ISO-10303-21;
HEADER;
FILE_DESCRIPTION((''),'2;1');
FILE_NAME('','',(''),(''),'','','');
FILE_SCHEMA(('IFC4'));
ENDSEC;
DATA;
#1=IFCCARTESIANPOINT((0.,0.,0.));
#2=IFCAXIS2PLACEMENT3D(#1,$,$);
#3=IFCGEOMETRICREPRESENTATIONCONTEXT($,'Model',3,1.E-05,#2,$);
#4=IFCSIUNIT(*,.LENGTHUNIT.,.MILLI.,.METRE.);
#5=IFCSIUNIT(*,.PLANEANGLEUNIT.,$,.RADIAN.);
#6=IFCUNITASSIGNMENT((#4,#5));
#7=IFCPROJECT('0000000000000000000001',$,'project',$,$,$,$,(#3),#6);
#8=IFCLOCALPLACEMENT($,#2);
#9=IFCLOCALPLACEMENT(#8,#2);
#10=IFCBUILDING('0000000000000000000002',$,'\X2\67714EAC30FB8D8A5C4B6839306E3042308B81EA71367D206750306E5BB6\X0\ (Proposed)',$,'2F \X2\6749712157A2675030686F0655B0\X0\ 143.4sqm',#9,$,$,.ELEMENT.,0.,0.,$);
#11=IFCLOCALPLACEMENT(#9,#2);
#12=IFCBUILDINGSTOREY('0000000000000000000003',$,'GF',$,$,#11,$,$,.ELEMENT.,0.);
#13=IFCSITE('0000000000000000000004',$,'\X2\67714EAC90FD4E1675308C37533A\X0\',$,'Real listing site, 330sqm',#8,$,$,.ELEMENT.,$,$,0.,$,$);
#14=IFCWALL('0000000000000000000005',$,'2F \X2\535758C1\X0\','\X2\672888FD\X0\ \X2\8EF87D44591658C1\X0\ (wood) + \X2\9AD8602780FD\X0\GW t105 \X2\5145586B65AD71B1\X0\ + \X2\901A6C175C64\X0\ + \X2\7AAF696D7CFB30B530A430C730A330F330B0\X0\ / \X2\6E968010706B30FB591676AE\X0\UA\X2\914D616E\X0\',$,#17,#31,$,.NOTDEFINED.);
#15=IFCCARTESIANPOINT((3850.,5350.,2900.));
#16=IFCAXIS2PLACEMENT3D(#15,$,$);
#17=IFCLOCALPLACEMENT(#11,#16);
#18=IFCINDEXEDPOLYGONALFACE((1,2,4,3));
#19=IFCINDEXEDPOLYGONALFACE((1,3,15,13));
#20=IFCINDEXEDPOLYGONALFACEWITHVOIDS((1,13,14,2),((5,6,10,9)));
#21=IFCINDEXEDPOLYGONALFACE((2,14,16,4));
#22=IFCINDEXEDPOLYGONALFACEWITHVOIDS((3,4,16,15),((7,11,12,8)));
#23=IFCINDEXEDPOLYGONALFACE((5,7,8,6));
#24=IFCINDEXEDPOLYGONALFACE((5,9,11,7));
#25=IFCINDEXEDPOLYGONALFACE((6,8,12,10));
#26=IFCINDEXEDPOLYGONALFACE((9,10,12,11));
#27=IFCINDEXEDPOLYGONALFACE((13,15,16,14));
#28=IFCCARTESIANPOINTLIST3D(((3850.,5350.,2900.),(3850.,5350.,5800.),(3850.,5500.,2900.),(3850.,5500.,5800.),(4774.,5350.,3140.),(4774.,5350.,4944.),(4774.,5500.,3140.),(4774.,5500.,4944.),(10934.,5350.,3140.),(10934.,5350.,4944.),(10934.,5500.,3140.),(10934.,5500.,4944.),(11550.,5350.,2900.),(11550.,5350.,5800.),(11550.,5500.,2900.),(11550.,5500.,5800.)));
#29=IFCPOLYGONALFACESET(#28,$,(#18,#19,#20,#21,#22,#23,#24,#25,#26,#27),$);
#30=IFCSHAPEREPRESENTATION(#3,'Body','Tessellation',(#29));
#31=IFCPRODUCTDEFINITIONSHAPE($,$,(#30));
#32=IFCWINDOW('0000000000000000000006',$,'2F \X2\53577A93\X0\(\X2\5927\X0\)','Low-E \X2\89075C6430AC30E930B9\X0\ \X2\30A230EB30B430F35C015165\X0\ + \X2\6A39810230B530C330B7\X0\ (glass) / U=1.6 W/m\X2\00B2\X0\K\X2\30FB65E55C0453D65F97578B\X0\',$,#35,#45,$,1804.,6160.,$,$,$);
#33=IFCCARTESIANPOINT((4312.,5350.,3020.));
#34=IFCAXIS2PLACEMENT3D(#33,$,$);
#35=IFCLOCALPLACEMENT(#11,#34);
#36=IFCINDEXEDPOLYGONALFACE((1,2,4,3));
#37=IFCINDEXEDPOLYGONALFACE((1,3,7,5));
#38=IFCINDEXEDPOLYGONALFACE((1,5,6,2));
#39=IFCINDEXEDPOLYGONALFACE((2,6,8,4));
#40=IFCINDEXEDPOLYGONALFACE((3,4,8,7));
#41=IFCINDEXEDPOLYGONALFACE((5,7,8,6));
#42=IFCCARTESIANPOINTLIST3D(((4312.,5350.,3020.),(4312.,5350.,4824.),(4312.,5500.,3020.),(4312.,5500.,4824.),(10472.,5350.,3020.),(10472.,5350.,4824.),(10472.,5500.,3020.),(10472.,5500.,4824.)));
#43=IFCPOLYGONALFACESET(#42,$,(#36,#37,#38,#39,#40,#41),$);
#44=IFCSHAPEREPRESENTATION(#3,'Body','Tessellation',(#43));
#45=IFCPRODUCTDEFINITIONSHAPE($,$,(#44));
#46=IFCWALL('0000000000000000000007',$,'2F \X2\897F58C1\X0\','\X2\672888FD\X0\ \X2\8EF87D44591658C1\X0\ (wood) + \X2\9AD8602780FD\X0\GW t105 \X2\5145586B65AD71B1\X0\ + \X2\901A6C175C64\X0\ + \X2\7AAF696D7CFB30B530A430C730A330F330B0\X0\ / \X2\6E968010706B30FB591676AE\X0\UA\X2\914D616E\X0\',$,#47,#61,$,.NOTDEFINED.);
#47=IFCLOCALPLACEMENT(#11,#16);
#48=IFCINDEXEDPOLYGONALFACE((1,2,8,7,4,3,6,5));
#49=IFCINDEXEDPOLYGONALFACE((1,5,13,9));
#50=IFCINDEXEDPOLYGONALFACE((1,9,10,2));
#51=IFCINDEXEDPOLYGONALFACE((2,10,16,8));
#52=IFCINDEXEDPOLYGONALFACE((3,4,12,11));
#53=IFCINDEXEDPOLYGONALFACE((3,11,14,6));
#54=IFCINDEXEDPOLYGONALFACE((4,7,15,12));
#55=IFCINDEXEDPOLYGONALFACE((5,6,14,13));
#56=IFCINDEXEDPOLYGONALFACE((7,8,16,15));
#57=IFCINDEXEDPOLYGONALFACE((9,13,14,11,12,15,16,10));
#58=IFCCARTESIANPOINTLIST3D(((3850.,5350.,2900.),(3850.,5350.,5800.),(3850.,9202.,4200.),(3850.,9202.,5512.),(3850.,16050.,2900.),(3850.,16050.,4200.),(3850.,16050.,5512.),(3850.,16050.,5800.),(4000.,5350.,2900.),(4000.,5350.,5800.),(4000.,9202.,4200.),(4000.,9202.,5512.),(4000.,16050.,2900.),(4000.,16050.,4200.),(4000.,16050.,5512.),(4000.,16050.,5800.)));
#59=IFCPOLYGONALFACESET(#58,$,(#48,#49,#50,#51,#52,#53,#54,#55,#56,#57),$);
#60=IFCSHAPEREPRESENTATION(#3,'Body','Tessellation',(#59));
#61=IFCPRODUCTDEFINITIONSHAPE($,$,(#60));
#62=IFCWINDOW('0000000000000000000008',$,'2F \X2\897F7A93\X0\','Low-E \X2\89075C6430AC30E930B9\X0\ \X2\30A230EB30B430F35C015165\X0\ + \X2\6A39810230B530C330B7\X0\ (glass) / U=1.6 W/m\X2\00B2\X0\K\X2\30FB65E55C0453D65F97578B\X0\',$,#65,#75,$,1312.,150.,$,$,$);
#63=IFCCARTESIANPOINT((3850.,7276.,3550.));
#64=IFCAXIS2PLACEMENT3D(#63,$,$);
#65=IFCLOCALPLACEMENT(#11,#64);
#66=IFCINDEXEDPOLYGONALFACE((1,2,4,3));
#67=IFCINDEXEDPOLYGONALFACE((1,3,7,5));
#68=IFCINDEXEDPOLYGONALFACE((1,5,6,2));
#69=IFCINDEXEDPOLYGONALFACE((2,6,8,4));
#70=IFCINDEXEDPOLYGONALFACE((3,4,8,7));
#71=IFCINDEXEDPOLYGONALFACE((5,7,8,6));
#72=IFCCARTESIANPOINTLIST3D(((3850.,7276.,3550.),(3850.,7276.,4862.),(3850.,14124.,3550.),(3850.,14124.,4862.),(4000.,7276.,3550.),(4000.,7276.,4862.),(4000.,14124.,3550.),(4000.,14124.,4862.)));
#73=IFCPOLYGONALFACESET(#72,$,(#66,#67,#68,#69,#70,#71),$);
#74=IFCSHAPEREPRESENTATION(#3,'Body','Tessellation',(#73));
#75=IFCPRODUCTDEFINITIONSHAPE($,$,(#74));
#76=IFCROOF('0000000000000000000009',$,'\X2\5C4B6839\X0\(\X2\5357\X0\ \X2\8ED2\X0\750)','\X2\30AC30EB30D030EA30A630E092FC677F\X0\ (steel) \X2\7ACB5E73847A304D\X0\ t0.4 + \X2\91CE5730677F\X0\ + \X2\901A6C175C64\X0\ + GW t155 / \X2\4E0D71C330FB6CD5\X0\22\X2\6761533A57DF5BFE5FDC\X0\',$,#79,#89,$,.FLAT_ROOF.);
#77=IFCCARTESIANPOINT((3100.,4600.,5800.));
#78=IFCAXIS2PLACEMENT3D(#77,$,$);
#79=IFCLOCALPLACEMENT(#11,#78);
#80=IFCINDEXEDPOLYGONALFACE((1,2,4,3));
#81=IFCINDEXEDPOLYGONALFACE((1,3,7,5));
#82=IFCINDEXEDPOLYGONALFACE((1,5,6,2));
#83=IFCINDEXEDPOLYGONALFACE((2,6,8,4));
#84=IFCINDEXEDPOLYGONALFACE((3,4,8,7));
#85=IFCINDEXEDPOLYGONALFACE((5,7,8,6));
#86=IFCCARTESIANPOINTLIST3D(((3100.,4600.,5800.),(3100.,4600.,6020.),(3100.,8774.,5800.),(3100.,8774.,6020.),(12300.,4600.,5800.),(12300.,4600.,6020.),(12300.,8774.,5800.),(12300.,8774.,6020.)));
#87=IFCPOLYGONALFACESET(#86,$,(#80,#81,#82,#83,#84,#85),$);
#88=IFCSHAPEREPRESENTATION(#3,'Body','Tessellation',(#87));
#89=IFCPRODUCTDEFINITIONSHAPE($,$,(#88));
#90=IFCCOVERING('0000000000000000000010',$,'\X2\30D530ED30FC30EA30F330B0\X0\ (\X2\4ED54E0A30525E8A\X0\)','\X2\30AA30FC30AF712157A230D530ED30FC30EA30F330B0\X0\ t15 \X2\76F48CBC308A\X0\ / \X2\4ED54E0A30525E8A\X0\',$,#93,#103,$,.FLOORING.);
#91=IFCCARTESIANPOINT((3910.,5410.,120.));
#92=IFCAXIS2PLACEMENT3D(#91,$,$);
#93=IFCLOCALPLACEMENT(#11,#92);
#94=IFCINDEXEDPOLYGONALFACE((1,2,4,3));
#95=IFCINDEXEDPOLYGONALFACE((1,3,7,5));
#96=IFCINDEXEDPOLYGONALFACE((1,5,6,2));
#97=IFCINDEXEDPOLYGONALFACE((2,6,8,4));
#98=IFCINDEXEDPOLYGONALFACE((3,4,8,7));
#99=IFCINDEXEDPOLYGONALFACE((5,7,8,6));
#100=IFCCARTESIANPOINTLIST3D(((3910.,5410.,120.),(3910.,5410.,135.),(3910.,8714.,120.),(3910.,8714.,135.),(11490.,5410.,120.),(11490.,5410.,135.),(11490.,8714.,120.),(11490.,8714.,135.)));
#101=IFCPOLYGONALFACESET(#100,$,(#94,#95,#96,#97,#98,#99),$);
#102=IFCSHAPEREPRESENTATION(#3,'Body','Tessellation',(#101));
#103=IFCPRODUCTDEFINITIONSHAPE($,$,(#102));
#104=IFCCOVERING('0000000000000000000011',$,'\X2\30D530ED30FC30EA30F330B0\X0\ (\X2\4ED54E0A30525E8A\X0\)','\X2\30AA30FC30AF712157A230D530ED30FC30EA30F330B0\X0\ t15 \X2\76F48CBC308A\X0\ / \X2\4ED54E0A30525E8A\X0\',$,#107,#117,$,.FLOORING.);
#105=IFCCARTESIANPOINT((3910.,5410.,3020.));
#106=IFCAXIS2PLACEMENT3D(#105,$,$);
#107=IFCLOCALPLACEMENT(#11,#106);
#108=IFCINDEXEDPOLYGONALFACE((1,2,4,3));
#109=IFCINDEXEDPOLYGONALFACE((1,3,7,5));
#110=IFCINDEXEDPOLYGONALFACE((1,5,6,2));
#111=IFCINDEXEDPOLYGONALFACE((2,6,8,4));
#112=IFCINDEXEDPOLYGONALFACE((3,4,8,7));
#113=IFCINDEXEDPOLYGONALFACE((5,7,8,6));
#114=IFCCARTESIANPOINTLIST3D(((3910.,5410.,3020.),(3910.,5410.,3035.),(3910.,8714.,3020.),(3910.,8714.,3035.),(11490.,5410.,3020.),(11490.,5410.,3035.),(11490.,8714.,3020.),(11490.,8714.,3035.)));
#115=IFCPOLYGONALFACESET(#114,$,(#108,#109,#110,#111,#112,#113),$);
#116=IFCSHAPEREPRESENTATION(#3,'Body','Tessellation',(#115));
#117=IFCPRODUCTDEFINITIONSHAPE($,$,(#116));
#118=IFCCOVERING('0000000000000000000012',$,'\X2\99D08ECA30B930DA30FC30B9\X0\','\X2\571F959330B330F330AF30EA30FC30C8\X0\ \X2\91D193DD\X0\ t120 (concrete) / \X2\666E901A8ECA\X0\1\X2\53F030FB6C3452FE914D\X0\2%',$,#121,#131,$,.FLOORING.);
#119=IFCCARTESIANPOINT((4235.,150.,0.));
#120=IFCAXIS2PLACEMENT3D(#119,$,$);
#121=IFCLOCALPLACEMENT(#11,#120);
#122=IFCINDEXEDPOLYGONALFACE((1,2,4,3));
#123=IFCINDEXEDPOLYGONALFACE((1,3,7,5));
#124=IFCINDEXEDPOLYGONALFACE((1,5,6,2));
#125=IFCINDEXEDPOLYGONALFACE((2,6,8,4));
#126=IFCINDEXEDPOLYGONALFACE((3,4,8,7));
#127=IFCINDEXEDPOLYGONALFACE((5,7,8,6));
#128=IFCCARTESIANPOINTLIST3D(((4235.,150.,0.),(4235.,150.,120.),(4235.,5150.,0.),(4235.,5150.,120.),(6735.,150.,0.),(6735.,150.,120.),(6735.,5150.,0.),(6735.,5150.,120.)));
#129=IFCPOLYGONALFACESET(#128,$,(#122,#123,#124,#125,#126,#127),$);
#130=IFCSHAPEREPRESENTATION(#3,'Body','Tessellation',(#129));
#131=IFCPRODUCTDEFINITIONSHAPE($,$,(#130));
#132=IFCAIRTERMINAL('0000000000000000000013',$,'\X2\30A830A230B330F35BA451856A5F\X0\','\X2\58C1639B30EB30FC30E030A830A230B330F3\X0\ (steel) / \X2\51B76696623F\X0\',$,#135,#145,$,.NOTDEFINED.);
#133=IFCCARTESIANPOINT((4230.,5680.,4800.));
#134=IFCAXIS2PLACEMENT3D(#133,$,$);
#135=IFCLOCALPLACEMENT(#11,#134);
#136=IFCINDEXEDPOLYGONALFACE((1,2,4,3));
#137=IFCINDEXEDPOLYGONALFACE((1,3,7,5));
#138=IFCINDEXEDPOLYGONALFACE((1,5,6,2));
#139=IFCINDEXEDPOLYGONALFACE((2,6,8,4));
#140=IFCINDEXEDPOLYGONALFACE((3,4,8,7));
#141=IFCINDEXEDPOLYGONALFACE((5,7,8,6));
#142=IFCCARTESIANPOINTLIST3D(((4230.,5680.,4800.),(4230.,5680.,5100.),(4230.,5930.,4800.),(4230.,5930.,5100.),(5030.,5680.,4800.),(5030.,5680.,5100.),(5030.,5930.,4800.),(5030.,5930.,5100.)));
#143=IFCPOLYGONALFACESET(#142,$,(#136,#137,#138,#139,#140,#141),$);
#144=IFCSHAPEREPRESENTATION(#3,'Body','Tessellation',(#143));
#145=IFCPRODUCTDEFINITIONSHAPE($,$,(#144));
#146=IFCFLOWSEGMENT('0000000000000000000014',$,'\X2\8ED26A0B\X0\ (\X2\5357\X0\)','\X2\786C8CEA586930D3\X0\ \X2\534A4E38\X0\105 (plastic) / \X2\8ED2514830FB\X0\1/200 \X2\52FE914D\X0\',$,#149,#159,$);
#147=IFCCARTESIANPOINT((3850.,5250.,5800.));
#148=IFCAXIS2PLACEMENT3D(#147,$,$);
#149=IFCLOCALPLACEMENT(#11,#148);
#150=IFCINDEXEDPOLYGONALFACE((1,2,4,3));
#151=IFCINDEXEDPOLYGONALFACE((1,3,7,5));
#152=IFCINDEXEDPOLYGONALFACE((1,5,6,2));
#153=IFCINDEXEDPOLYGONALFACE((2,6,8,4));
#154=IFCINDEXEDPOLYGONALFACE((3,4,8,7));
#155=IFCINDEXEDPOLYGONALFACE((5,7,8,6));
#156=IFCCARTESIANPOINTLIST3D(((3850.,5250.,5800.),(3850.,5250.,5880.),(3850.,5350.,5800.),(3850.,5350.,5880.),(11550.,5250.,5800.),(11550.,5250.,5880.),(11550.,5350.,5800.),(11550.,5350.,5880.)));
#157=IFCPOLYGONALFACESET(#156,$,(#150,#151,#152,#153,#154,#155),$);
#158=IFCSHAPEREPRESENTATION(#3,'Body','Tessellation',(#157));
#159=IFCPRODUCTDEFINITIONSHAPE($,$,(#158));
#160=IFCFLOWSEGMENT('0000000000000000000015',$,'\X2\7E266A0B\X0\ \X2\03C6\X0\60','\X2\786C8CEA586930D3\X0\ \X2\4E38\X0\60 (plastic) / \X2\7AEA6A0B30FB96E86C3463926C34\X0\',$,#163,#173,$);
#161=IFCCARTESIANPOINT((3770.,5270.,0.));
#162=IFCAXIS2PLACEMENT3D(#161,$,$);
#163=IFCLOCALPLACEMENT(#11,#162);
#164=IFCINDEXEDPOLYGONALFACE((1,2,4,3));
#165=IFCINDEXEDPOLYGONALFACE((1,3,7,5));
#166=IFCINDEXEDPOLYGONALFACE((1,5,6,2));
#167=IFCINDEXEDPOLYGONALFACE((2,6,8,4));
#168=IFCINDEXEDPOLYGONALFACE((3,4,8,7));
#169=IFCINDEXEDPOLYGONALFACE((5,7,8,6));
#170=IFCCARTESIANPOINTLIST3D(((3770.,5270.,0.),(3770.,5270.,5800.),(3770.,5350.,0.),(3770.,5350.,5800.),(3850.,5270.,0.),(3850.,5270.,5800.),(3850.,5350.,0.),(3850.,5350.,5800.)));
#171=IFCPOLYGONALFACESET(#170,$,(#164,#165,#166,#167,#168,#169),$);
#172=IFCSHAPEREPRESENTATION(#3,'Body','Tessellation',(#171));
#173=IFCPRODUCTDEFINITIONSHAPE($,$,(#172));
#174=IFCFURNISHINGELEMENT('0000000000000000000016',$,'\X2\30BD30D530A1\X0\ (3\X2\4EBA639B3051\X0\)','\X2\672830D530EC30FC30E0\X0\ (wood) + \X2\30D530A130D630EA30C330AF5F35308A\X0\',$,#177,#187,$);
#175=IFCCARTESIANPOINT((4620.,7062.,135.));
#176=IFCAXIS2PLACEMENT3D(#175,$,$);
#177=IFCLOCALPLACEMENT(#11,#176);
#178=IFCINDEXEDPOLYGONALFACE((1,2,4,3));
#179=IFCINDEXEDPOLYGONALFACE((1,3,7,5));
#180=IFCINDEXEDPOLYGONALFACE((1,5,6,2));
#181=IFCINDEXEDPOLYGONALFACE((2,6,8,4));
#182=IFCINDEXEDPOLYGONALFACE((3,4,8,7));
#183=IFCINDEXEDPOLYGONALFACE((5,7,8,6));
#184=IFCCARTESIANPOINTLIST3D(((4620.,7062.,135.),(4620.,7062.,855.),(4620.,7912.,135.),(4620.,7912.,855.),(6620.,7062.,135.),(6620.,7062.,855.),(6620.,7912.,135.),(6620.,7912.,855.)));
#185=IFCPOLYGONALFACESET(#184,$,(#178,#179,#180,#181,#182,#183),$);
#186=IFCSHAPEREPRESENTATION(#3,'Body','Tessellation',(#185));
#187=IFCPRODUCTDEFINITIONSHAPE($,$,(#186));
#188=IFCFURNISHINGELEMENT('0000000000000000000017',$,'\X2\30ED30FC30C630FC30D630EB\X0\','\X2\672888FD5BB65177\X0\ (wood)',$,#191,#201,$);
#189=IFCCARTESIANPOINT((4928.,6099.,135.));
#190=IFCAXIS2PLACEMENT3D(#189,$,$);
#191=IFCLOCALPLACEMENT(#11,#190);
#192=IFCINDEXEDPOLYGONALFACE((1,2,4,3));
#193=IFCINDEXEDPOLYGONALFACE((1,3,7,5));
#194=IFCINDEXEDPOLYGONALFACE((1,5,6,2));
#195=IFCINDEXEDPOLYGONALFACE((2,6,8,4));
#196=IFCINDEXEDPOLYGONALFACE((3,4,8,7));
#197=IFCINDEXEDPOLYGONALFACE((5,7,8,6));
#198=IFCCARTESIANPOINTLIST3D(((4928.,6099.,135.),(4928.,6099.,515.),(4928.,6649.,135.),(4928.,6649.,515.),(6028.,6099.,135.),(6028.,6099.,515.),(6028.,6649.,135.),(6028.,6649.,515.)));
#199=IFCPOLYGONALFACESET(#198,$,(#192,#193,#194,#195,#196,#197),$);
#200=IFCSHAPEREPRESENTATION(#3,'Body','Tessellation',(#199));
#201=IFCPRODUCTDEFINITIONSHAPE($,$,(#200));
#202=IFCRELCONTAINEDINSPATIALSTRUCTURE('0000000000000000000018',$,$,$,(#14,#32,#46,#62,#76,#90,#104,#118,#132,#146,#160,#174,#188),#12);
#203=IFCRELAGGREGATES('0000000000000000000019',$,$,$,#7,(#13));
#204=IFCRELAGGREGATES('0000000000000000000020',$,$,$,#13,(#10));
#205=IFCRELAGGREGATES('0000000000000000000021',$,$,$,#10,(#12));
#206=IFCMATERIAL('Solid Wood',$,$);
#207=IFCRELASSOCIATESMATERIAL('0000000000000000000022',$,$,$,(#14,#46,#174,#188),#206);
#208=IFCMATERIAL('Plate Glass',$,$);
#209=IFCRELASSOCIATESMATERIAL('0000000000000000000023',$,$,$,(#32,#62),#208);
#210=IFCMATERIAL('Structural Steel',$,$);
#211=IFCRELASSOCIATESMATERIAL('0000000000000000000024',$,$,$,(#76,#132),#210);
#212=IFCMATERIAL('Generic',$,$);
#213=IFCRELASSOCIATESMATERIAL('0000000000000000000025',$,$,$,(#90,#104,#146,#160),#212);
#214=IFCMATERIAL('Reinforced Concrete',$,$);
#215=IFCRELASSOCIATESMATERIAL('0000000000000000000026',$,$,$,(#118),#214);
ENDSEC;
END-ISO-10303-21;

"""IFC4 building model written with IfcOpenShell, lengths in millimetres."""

from ifc_helpers import new_model, si_unit, frame, frame_2d, origin, place, context, project, spatial, rectangle, extrude, material, element, fill, save


model = new_model("IFC4")

# Units and contexts
model_context = context("Model", 3, precision=1e-05, world=origin())
ifc_project = project(units=[si_unit("LENGTHUNIT", "METRE", prefix="MILLI"), si_unit("PLANEANGLEUNIT", "RADIAN")], contexts=[model_context])

# Site, building, storey
site_placement = place(None, origin())
site = spatial("IfcSite", under=ifc_project, at=site_placement, Name="東京都世田谷区", ObjectType="Real listing site, 330sqm", CompositionType="ELEMENT", RefElevation=0.0)
building_placement = place(site_placement, origin())
building = spatial("IfcBuilding", under=site, at=building_placement, Name="東京・越屋根のある自然素材の家 (Proposed)", ObjectType="2F 杉無垢材と漆喰 143.4sqm", CompositionType="ELEMENT", ElevationOfRefHeight=0.0, ElevationOfTerrain=0.0)
storey_placement = place(building_placement, origin())
storey = spatial("IfcBuildingStorey", under=building, at=storey_placement, Name="GF", CompositionType="ELEMENT", Elevation=0.0)

# Shared definitions
ifc_material_1 = material(Name="Solid Wood")

# Shared definitions
ifc_material_2 = material(Name="Reinforced Concrete")

# Shared definitions
ifc_material_3 = material(Name="Plate Glass")

# Walls, openings, windows
wall_1_placement = place(storey_placement, frame((3850.0, 5350.0, 2900.0)))
wall_1 = element("IfcWall", 1, at=wall_1_placement, inside=storey, material=ifc_material_1, Name="2F 南壁", Description="木製 軸組外壁 (wood) + 高性能GW t105 充填断熱 + 通気層 + 窯業系サイディング / 準耐火・外皮UA配慮", PredefinedType="NOTDEFINED", context=model_context, shape_type="SweptSolid", body=[
    extrude(rectangle(XDim=7700.0, YDim=150.0, at=frame_2d((3850.0, 75.0))), frame((3850.0, 5350.0, 2900.0)), (0.0, 0.0, 1.0), 2900.0),
])
opening_1_placement = place(storey_placement, frame((4312.0, 5350.0, 3020.0)))
opening_1 = element("IfcOpeningElement", 2, at=opening_1_placement, cuts=wall_1, PredefinedType="NOTDEFINED", context=model_context, shape_type="SweptSolid", body=[
    extrude(rectangle(XDim=6160.0, YDim=150.0, at=frame_2d((3080.0, 75.0))), frame((4312.0, 5350.0, 3020.0)), (0.0, 0.0, 1.0), 1804.0),
])
window_1_placement = place(storey_placement, frame((4312.0, 5350.0, 3020.0)))
window_1 = element("IfcWindow", 3, at=window_1_placement, inside=storey, material=ifc_material_3, Name="2F 南窓(大)", Description="Low-E 複層ガラス アルゴン封入 + 樹脂サッシ (glass) / U=1.6 W/m²K・日射取得型", OverallHeight=1804.0, OverallWidth=6160.0, context=model_context, shape_type="SweptSolid", body=[
    extrude(rectangle(XDim=6160.0, YDim=150.0, at=frame_2d((3080.0, 75.0))), frame((4312.0, 5350.0, 3020.0)), (0.0, 0.0, 1.0), 1804.0),
])
fill(opening_1, window_1)
wall_2_placement = place(storey_placement, frame((3850.0, 5350.0, 2900.0)))
wall_2 = element("IfcWall", 4, at=wall_2_placement, inside=storey, material=ifc_material_1, Name="2F 西壁", Description="木製 軸組外壁 (wood) + 高性能GW t105 充填断熱 + 通気層 + 窯業系サイディング / 準耐火・外皮UA配慮", PredefinedType="NOTDEFINED", context=model_context, shape_type="SweptSolid", body=[
    extrude(rectangle(XDim=150.0, YDim=10700.0, at=frame_2d((75.0, 5350.0))), frame((3850.0, 5350.0, 2900.0)), (0.0, 0.0, 1.0), 2900.0),
])
opening_2_placement = place(storey_placement, frame((3850.0, 7276.0, 3550.0)))
opening_2 = element("IfcOpeningElement", 5, at=opening_2_placement, cuts=wall_2, PredefinedType="NOTDEFINED", context=model_context, shape_type="SweptSolid", body=[
    extrude(rectangle(XDim=150.0, YDim=6848.0, at=frame_2d((75.0, 3424.0))), frame((3850.0, 7276.0, 3550.0)), (0.0, 0.0, 1.0), 1312.0),
])
window_2_placement = place(storey_placement, frame((3850.0, 7276.0, 3550.0)))
window_2 = element("IfcWindow", 6, at=window_2_placement, inside=storey, material=ifc_material_3, Name="2F 西窓", Description="Low-E 複層ガラス アルゴン封入 + 樹脂サッシ (glass) / U=1.6 W/m²K・日射取得型", OverallHeight=1312.0, OverallWidth=150.0, context=model_context, shape_type="SweptSolid", body=[
    extrude(rectangle(XDim=150.0, YDim=6848.0, at=frame_2d((75.0, 3424.0))), frame((3850.0, 7276.0, 3550.0)), (0.0, 0.0, 1.0), 1312.0),
])
fill(opening_2, window_2)

# Roof
ifc_material_4 = material(Name="Structural Steel")
for number, where, name in (
    (7, (3100.0, 4600.0, 5800.0), "屋根(南 軒750)"),
):
    element("IfcRoof", number, at=place(storey_placement, frame(where)), inside=storey, material=ifc_material_4, Name=name, Description="ガルバリウム鋼板 (steel) 立平葺き t0.4 + 野地板 + 通気層 + GW t155 / 不燃・法22条区域対応", PredefinedType="FLAT_ROOF", context=model_context, shape_type="SweptSolid", body=[
        extrude(rectangle(XDim=9200.0, YDim=4174.0, at=frame_2d((4600.0, 2087.0))), frame((3100.0, 4600.0, 5800.0)), (0.0, 0.0, 1.0), 220.0),
    ])

# Coverings
ifc_material_5 = material(Name="Generic")
covering_1_placement = place(storey_placement, frame((3910.0, 5410.0, 120.0)))
element("IfcCovering", 8, at=covering_1_placement, inside=storey, material=ifc_material_5, Name="フローリング (仕上げ床)", Description="オーク無垢フローリング t15 直貼り / 仕上げ床", PredefinedType="FLOORING", context=model_context, shape_type="SweptSolid", body=[
    extrude(rectangle(XDim=7580.0, YDim=3304.0, at=frame_2d((3790.0, 1652.0))), frame((3910.0, 5410.0, 120.0)), (0.0, 0.0, 1.0), 15.0),
])
covering_2_placement = place(storey_placement, frame((3910.0, 5410.0, 3020.0)))
element("IfcCovering", 9, at=covering_2_placement, inside=storey, material=ifc_material_5, Name="フローリング (仕上げ床)", Description="オーク無垢フローリング t15 直貼り / 仕上げ床", PredefinedType="FLOORING", context=model_context, shape_type="SweptSolid", body=[
    extrude(rectangle(XDim=7580.0, YDim=3304.0, at=frame_2d((3790.0, 1652.0))), frame((3910.0, 5410.0, 3020.0)), (0.0, 0.0, 1.0), 15.0),
])
covering_3_placement = place(storey_placement, frame((4235.0, 150.0, 0.0)))
element("IfcCovering", 10, at=covering_3_placement, inside=storey, material=ifc_material_2, Name="駐車スペース", Description="土間コンクリート 金鏝 t120 (concrete) / 普通車1台・水勾配2%", PredefinedType="FLOORING", context=model_context, shape_type="SweptSolid", body=[
    extrude(rectangle(XDim=2500.0, YDim=5000.0, at=frame_2d((1250.0, 2500.0))), frame((4235.0, 150.0, 0.0)), (0.0, 0.0, 1.0), 120.0),
])

# Air terminal
air_terminal_placement = place(storey_placement, frame((4230.0, 5680.0, 4800.0)))
element("IfcAirTerminal", 11, at=air_terminal_placement, inside=storey, material=ifc_material_4, Name="エアコン室内機", Description="壁掛ルームエアコン (steel) / 冷暖房", PredefinedType="NOTDEFINED", context=model_context, shape_type="SweptSolid", body=[
    extrude(rectangle(XDim=800.0, YDim=250.0, at=frame_2d((400.0, 125.0))), frame((4230.0, 5680.0, 4800.0)), (0.0, 0.0, 1.0), 300.0),
])

# Flow segments
flow_segment_1_placement = place(storey_placement, frame((3850.0, 5250.0, 5800.0)))
element("IfcFlowSegment", 12, at=flow_segment_1_placement, inside=storey, material=ifc_material_5, Name="軒樋 (南)", Description="硬質塩ビ 半丸105 (plastic) / 軒先・1/200 勾配", context=model_context, shape_type="SweptSolid", body=[
    extrude(rectangle(XDim=7700.0, YDim=100.0, at=frame_2d((3850.0, 50.0))), frame((3850.0, 5250.0, 5800.0)), (0.0, 0.0, 1.0), 80.0),
])
flow_segment_2_placement = place(storey_placement, frame((3770.0, 5270.0, 0.0)))
element("IfcFlowSegment", 13, at=flow_segment_2_placement, inside=storey, material=ifc_material_5, Name="縦樋 φ60", Description="硬質塩ビ 丸60 (plastic) / 竪樋・雨水排水", context=model_context, shape_type="SweptSolid", body=[
    extrude(rectangle(XDim=80.0, YDim=80.0, at=frame_2d((40.0, 40.0))), frame((3770.0, 5270.0, 0.0)), (0.0, 0.0, 1.0), 5800.0),
])

# Furnishing elements
furnishing_1_placement = place(storey_placement, frame((4620.0, 7062.0, 135.0)))
element("IfcFurnishingElement", 14, at=furnishing_1_placement, inside=storey, material=ifc_material_1, Name="ソファ (3人掛け)", Description="木フレーム (wood) + ファブリック張り", context=model_context, shape_type="SweptSolid", body=[
    extrude(rectangle(XDim=2000.0, YDim=850.0, at=frame_2d((1000.0, 425.0))), frame((4620.0, 7062.0, 135.0)), (0.0, 0.0, 1.0), 720.0),
])
furnishing_2_placement = place(storey_placement, frame((4928.0, 6099.0, 135.0)))
element("IfcFurnishingElement", 15, at=furnishing_2_placement, inside=storey, material=ifc_material_1, Name="ローテーブル", Description="木製家具 (wood)", context=model_context, shape_type="SweptSolid", body=[
    extrude(rectangle(XDim=1100.0, YDim=550.0, at=frame_2d((550.0, 275.0))), frame((4928.0, 6099.0, 135.0)), (0.0, 0.0, 1.0), 380.0),
])

save(model, "model.ifc")
